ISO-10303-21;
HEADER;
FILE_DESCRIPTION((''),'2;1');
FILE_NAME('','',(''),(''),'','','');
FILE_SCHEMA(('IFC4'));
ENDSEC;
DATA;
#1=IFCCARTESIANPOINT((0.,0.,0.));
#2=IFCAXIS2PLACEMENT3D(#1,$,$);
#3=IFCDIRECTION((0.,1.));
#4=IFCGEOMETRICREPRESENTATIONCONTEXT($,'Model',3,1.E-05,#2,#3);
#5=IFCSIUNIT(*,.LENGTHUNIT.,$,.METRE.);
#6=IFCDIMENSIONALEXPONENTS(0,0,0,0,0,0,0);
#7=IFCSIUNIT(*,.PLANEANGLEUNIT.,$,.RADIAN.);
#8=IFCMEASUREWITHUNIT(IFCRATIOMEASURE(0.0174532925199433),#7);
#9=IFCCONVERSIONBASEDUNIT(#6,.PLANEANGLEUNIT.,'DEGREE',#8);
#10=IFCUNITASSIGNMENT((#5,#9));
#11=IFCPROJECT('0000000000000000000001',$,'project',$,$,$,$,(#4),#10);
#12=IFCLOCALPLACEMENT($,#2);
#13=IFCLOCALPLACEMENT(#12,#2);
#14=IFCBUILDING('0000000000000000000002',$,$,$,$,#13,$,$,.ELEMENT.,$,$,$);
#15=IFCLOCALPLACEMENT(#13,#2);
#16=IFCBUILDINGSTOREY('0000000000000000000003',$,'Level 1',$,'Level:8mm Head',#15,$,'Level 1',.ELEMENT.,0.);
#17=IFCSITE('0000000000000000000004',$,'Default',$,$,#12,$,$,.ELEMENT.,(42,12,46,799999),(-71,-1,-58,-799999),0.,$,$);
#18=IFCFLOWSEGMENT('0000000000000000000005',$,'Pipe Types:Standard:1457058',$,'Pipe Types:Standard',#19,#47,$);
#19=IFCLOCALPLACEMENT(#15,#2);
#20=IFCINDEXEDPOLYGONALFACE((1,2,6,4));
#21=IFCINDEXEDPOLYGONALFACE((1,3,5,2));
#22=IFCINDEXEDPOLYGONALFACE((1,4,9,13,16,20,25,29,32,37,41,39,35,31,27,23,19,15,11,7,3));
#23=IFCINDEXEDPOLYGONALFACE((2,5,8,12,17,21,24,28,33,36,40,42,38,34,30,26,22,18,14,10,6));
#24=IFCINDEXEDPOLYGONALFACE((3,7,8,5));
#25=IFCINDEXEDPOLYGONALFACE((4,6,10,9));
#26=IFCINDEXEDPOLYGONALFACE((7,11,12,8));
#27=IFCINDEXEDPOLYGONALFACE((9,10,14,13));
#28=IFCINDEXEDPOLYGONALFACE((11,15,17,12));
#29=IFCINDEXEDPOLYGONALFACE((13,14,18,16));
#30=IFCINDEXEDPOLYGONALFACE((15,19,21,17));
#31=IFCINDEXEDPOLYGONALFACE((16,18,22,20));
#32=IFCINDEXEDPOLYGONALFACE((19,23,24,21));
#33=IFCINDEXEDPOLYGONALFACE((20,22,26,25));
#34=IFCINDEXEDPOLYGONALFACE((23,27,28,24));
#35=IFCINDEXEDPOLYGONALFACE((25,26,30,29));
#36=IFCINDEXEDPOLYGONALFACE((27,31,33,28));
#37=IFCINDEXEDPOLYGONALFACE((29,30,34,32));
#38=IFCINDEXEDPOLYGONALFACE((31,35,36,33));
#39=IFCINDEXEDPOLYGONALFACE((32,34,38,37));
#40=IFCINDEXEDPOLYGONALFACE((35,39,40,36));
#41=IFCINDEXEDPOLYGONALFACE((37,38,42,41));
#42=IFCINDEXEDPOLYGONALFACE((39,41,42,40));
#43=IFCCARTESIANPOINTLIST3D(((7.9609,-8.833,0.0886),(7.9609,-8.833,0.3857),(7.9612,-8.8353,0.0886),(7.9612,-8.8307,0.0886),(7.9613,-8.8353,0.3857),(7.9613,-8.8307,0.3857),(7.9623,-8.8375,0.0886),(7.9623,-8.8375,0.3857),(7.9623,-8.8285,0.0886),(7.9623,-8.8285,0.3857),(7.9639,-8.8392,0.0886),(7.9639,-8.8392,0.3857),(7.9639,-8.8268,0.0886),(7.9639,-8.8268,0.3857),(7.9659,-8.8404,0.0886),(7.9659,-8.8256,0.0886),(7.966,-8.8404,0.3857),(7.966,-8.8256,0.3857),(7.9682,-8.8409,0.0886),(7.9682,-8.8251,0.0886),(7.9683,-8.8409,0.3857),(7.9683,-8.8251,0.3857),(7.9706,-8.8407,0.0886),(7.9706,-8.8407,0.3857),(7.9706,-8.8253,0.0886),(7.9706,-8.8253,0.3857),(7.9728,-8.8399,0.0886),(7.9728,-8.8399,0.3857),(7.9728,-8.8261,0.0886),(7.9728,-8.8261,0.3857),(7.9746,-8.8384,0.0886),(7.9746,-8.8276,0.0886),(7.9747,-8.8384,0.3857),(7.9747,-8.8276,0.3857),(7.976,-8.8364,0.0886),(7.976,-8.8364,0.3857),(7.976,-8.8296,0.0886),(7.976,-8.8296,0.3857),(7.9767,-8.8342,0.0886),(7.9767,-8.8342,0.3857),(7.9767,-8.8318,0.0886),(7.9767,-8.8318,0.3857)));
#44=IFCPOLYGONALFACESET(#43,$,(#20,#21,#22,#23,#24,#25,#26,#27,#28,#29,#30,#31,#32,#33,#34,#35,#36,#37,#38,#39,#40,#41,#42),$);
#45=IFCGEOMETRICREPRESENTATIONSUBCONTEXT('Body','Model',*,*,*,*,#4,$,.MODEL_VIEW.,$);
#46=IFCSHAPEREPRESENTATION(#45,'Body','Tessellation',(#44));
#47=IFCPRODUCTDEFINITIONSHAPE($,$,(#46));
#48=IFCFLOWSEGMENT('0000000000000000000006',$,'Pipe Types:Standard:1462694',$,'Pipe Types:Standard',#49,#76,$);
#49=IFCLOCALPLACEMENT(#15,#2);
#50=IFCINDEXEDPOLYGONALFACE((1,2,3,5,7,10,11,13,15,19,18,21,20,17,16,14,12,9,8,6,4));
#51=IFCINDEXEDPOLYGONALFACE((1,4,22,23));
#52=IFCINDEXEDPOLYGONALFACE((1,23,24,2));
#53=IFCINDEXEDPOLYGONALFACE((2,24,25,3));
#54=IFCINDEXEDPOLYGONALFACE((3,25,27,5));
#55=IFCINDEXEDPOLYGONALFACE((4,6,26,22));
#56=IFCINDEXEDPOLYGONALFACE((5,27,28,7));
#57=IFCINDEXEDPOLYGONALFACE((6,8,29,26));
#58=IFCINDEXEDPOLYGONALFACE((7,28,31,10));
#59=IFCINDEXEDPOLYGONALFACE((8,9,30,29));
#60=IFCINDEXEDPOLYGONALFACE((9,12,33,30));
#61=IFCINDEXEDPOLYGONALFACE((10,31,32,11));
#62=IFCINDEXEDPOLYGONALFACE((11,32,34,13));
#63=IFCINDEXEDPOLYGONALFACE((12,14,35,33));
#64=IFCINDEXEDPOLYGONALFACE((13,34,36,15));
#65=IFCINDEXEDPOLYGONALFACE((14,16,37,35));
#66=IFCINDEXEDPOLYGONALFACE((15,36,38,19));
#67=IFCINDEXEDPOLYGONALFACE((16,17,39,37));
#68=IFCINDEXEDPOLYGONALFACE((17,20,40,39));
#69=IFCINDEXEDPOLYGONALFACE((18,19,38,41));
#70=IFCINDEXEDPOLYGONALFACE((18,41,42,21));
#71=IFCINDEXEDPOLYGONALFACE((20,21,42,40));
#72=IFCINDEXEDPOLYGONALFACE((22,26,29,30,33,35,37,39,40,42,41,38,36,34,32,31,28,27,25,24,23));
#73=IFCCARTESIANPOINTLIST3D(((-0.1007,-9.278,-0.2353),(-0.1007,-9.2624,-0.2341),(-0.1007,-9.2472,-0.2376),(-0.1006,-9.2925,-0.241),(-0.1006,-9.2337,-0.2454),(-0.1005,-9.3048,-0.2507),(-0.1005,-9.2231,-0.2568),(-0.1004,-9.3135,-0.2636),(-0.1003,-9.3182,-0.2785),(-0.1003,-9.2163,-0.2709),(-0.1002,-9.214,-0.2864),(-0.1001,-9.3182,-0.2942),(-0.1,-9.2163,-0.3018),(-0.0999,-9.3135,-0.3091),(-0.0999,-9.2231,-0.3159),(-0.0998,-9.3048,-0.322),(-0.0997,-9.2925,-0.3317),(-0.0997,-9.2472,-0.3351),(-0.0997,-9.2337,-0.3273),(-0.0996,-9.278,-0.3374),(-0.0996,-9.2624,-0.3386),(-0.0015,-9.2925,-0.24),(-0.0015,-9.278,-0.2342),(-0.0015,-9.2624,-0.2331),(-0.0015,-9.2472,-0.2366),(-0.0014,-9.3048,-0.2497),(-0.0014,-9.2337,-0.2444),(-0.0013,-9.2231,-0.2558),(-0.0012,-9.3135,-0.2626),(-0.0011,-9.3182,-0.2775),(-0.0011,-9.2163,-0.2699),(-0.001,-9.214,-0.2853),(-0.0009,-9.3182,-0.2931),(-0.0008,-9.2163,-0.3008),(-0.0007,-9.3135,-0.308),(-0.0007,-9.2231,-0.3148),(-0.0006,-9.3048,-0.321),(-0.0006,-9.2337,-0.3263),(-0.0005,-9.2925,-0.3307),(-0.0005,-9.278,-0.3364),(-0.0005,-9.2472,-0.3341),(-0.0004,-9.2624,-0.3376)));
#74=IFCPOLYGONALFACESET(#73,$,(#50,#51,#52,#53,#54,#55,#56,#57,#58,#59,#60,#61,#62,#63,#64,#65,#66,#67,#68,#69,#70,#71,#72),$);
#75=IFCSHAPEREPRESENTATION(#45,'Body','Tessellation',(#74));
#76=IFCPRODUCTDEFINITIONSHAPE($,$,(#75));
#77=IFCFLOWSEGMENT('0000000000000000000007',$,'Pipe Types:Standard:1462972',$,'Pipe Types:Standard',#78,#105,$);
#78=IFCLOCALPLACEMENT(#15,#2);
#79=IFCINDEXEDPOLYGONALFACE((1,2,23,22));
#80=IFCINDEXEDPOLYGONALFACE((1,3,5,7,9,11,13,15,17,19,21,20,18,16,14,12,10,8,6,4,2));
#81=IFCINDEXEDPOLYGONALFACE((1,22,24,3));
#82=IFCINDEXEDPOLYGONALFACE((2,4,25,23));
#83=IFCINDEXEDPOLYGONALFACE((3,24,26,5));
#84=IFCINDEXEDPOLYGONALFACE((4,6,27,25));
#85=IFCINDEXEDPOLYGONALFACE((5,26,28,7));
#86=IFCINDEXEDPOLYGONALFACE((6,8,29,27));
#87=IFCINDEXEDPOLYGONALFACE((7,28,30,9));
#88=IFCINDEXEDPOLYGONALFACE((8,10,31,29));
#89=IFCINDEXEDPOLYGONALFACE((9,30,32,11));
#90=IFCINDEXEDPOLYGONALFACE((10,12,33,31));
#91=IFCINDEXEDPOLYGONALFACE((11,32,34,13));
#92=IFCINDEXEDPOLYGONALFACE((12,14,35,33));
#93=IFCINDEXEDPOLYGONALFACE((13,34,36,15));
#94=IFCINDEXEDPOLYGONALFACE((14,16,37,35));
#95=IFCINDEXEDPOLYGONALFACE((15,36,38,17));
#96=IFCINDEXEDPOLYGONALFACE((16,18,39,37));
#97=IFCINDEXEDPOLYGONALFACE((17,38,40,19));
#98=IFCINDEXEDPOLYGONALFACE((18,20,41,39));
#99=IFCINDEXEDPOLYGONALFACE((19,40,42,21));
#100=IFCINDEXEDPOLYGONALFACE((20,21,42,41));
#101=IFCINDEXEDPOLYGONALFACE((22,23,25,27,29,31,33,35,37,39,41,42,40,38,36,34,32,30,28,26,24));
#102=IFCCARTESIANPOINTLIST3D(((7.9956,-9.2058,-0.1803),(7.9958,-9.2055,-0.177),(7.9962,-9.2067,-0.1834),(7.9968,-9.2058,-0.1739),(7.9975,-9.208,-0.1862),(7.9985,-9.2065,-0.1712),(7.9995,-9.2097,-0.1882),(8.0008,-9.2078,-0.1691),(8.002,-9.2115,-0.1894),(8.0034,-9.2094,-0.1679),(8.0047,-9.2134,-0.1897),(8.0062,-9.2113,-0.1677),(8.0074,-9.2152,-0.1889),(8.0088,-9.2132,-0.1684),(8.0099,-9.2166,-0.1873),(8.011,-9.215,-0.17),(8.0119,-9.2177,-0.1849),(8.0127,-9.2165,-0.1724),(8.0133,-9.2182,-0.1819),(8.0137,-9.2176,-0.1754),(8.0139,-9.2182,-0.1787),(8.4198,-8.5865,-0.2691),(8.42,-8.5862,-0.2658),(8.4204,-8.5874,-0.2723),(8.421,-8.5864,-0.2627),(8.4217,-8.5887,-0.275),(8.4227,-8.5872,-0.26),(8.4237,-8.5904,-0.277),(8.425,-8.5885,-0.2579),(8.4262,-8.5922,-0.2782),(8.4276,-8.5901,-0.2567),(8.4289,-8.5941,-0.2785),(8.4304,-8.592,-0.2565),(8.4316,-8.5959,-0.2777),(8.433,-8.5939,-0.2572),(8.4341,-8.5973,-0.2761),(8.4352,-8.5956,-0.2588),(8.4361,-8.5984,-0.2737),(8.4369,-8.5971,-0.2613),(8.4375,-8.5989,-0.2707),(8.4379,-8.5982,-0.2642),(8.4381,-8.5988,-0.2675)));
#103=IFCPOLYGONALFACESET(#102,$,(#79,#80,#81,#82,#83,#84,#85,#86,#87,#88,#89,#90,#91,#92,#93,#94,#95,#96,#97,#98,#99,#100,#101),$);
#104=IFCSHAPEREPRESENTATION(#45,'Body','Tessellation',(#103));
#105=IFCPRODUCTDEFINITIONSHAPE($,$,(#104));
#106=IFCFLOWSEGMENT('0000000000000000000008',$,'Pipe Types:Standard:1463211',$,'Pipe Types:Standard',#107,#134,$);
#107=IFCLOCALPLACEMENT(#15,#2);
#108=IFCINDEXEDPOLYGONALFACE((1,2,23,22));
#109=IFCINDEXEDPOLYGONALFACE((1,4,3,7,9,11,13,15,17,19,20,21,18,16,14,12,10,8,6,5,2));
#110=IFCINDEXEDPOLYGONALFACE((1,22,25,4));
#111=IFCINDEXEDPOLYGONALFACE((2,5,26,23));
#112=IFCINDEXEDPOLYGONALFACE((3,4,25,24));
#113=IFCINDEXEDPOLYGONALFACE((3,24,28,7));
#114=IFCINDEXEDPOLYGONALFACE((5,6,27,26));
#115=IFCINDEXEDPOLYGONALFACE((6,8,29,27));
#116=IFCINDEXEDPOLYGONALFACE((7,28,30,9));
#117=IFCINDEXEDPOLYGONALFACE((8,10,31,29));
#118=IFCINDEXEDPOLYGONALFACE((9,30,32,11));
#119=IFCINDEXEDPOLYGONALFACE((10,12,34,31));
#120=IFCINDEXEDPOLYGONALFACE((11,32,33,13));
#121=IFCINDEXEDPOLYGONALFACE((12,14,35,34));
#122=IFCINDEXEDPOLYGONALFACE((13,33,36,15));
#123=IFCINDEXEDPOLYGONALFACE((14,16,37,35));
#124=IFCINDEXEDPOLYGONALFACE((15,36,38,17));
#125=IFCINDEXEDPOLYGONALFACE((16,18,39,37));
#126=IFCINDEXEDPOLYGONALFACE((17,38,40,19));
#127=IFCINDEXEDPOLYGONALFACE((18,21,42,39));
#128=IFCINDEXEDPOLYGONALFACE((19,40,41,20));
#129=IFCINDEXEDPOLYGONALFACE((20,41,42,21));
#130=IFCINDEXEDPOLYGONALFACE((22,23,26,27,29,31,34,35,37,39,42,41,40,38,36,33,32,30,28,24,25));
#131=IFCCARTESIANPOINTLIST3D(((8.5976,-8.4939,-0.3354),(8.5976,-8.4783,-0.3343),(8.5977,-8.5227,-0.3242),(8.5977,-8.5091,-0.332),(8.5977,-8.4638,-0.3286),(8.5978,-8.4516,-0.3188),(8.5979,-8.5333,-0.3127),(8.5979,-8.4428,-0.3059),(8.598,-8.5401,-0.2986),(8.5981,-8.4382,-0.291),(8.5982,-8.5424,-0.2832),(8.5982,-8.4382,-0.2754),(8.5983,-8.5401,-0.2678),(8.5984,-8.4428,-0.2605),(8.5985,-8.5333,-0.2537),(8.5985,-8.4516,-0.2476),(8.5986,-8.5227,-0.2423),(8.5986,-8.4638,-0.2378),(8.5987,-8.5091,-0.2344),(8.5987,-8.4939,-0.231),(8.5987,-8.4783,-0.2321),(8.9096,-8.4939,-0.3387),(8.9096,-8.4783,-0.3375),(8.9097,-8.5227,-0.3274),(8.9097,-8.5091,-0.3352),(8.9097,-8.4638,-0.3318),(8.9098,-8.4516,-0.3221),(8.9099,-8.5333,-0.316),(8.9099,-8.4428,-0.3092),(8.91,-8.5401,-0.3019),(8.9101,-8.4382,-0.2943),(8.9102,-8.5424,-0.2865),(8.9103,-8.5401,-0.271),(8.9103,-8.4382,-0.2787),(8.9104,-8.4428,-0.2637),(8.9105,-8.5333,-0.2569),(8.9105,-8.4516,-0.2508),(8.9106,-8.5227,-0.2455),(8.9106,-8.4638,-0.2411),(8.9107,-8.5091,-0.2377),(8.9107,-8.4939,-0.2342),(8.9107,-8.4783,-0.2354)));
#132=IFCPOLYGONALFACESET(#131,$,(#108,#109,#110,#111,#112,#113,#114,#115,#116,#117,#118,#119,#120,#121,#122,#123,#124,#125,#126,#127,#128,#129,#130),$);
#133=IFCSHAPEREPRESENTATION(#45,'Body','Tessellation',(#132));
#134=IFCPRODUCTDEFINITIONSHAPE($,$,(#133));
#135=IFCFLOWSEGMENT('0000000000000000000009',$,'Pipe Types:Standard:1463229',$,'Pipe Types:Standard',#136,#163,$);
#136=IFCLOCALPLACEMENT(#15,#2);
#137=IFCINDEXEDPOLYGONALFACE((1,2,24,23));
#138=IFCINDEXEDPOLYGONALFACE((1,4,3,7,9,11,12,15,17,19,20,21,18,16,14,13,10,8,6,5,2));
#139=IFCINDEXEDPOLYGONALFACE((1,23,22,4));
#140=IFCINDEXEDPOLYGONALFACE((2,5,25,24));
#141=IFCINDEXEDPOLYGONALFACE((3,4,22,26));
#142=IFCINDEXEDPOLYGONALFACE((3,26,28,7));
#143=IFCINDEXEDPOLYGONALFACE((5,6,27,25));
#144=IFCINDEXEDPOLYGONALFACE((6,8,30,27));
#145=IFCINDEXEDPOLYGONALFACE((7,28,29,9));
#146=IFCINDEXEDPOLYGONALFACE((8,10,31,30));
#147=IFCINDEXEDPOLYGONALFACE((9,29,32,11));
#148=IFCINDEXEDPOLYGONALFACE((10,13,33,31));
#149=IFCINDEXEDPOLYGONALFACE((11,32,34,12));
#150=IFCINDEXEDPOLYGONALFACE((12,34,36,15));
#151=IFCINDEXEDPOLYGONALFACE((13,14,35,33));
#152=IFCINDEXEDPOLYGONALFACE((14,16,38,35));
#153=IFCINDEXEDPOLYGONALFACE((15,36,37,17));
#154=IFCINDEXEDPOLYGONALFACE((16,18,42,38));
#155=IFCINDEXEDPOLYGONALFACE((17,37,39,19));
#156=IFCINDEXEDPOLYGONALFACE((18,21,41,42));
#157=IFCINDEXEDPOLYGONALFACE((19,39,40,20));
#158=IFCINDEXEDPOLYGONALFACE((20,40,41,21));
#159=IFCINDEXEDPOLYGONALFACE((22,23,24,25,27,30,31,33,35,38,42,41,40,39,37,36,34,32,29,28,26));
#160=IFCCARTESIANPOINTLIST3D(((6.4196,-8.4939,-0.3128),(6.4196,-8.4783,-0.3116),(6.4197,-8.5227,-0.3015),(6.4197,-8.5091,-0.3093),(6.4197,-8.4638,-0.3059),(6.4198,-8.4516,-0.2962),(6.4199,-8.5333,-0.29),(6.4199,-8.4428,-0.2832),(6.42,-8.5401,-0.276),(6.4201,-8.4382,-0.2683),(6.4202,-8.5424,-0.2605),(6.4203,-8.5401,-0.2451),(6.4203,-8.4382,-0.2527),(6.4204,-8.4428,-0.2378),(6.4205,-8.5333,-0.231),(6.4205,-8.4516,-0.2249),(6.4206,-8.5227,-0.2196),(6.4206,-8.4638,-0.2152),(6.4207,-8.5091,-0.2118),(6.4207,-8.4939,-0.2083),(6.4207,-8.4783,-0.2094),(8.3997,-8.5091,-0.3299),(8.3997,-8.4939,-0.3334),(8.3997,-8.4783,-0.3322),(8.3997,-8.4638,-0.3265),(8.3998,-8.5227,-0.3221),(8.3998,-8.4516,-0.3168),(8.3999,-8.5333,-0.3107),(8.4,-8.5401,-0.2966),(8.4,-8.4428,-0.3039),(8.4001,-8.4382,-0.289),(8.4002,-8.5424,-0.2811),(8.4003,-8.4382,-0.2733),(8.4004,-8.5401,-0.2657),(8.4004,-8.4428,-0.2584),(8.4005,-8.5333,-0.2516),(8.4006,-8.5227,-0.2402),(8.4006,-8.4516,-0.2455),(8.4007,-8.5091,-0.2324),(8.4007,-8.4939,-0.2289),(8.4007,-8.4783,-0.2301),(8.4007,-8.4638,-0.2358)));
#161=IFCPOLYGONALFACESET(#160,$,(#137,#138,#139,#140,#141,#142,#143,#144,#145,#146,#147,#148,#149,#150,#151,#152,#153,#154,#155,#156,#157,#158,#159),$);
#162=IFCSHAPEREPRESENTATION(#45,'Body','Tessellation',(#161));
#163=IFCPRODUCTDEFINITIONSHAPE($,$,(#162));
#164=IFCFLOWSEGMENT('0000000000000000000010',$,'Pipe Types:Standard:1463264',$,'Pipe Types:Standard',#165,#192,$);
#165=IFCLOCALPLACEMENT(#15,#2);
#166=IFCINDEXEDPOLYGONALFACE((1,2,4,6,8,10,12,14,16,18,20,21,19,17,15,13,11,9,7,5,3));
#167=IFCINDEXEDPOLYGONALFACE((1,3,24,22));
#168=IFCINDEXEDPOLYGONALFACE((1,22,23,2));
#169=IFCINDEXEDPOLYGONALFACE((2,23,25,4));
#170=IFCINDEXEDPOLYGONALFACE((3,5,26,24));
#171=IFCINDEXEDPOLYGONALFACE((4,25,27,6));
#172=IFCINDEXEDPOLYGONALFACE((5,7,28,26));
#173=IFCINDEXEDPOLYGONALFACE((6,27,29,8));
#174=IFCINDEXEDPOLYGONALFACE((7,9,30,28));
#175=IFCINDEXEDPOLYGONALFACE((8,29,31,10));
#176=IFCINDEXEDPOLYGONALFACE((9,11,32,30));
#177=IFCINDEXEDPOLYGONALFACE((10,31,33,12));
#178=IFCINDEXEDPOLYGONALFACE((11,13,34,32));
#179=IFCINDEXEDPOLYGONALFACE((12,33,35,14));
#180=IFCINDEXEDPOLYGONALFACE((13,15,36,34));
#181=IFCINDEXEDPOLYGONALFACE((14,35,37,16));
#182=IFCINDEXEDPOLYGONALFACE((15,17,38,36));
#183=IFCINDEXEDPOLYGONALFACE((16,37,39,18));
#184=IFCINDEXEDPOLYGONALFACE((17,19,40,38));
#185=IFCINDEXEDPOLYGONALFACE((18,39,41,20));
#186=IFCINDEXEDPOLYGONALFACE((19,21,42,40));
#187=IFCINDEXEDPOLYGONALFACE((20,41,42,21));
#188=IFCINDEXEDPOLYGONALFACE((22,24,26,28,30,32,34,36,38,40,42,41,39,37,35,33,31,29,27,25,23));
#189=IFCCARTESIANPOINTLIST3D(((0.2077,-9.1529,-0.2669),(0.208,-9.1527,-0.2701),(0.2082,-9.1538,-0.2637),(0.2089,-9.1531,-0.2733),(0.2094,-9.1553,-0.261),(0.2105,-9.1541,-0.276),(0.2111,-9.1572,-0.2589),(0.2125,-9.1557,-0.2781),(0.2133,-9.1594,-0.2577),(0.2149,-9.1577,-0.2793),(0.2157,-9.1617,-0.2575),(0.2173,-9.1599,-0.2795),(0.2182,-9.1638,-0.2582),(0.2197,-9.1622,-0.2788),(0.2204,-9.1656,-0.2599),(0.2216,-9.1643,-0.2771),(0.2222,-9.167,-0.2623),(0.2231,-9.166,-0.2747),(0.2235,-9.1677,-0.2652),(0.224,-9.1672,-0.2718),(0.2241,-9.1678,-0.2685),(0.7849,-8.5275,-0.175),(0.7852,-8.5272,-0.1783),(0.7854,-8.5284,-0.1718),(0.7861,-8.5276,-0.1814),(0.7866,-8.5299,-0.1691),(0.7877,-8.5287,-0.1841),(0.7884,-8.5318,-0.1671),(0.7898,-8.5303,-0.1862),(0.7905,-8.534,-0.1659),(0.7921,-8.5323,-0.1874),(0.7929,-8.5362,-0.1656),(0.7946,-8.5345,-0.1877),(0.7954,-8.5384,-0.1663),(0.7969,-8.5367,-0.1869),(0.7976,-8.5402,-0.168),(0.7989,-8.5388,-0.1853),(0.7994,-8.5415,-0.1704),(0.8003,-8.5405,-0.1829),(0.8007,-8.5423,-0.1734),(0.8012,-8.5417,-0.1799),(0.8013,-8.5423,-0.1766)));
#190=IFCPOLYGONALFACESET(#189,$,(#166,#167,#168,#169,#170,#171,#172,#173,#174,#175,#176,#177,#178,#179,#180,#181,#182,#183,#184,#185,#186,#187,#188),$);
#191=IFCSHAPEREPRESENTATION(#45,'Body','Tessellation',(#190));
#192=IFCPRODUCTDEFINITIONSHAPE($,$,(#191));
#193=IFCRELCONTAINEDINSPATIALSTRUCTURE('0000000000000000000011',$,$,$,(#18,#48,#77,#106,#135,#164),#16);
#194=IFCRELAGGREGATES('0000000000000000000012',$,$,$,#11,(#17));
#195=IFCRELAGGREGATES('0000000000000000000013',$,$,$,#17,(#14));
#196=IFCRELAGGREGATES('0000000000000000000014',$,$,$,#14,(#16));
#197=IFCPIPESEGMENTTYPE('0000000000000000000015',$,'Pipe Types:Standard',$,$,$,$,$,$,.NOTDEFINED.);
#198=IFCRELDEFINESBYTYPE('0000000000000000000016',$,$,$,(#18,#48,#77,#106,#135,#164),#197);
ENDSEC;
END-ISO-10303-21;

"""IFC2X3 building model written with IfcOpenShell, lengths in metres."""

from ifc_helpers import new_model, entity, si_unit, converted_unit, direction, frame, frame_2d, origin, origin_2d_with_axis, place, context, subcontext, project, spatial, circle, extrude, type_object, element, save


model = new_model("IFC2X3")

# Units and contexts
model_context = context("Model", 3, precision=1e-05, world=origin(), true_north=direction((0.0, 1.0)))
body_context = subcontext(model_context, "Body", "Model", "MODEL_VIEW")
ifc_project = project(units=[si_unit("LENGTHUNIT", "METRE"), converted_unit("PLANEANGLEUNIT", "DEGREE", entity("IfcRatioMeasure", 0.0174532925199433), si_unit("PLANEANGLEUNIT", "RADIAN"), dimensions=[0, 0, 0, 0, 0, 0, 0])], contexts=[model_context])

# Site, building, storey
site_placement = place(None, origin())
site = spatial("IfcSite", under=ifc_project, at=site_placement, Name="Default", CompositionType="ELEMENT", RefLatitude=(42, 12, 46, 799999), RefLongitude=(-71, -1, -58, -799999), RefElevation=0.0)
building_placement = place(site_placement, origin())
building = spatial("IfcBuilding", under=site, at=building_placement, CompositionType="ELEMENT")
storey_placement = place(building_placement, origin())
storey = spatial("IfcBuildingStorey", under=building, at=storey_placement, Name="Level 1", ObjectType="Level:8mm Head", LongName="Level 1", CompositionType="ELEMENT", Elevation=0.0)

# Flow segments
pipe_segment_type = type_object("IfcPipeSegmentType", Name="Pipe Types:Standard", PredefinedType="NOTDEFINED")
flow_segment_1_placement = place(storey_placement, origin())
element("IfcFlowSegment", 1, at=flow_segment_1_placement, inside=storey, type_object=pipe_segment_type, Name="Pipe Types:Standard:1457058", ObjectType="Pipe Types:Standard", context=body_context, shape_type="SweptSolid", body=[
    extrude(circle(Radius=0.0079, at=origin_2d_with_axis()), frame((7.9688, -8.833, 0.0886), z_axis=(0.000144, 0.0, 1.0), x_axis=(-1.0, 0.0, 0.000144)), (0.0, 0.0, 1.0), 0.2971),
])
flow_segment_2_placement = place(storey_placement, origin())
element("IfcFlowSegment", 2, at=flow_segment_2_placement, inside=storey, type_object=pipe_segment_type, Name="Pipe Types:Standard:1462694", ObjectType="Pipe Types:Standard", context=body_context, shape_type="SweptSolid", body=[
    extrude(circle(Radius=0.0524, at=frame_2d((0.0, 0.0), x_axis=(1.0, 0.0))), frame((-0.1002, -9.2664, -0.2864), z_axis=(0.999946, 0.0, 0.010416), x_axis=(0.0, 1.0, 0.0)), (0.0, 0.0, 1.0), 0.0992),
])
flow_segment_3_placement = place(storey_placement, origin())
element("IfcFlowSegment", 3, at=flow_segment_3_placement, inside=storey, type_object=pipe_segment_type, Name="Pipe Types:Standard:1462972", ObjectType="Pipe Types:Standard", context=body_context, shape_type="SweptSolid", body=[
    extrude(circle(Radius=0.0111, at=frame_2d((0.0, 0.0), x_axis=(1.0, 0.0))), frame((8.0048, -9.2119, -0.1787), z_axis=(0.561169, 0.81932, -0.117492), x_axis=(0.825034, -0.565083, 0.0)), (0.0, 0.0, 1.0), 0.7559),
])
flow_segment_4_placement = place(storey_placement, origin())
element("IfcFlowSegment", 4, at=flow_segment_4_placement, inside=storey, type_object=pipe_segment_type, Name="Pipe Types:Standard:1463211", ObjectType="Pipe Types:Standard", context=body_context, shape_type="SweptSolid", body=[
    extrude(circle(Radius=0.0524, at=frame_2d((0.0, 0.0), x_axis=(1.0, 0.0))), frame((8.5982, -8.49, -0.2832), z_axis=(0.999946, 0.0, -0.010416), x_axis=(0.0, -1.0, 0.0)), (0.0, 0.0, 1.0), 0.312),
])
flow_segment_5_placement = place(storey_placement, origin())
element("IfcFlowSegment", 5, at=flow_segment_5_placement, inside=storey, type_object=pipe_segment_type, Name="Pipe Types:Standard:1463229", ObjectType="Pipe Types:Standard", context=body_context, shape_type="SweptSolid", body=[
    extrude(circle(Radius=0.0524, at=frame_2d((0.0, 0.0), x_axis=(1.0, 0.0))), frame((8.4002, -8.49, -0.2811), z_axis=(-0.999946, 0.0, 0.010416), x_axis=(0.0, -1.0, 0.0)), (0.0, 0.0, 1.0), 1.9801),
])
flow_segment_6_placement = place(storey_placement, origin())
element("IfcFlowSegment", 6, at=flow_segment_6_placement, inside=storey, type_object=pipe_segment_type, Name="Pipe Types:Standard:1463264", ObjectType="Pipe Types:Standard", context=body_context, shape_type="SweptSolid", body=[
    extrude(circle(Radius=0.0111, at=frame_2d((0.0, 0.0), x_axis=(1.0, 0.0))), frame((0.2159, -9.1603, -0.2685), z_axis=(0.674281, 0.730636, 0.107313), x_axis=(0.73488, -0.678198, 0.0)), (0.0, 0.0, 1.0), 0.856),
])

save(model, "model.ifc")
